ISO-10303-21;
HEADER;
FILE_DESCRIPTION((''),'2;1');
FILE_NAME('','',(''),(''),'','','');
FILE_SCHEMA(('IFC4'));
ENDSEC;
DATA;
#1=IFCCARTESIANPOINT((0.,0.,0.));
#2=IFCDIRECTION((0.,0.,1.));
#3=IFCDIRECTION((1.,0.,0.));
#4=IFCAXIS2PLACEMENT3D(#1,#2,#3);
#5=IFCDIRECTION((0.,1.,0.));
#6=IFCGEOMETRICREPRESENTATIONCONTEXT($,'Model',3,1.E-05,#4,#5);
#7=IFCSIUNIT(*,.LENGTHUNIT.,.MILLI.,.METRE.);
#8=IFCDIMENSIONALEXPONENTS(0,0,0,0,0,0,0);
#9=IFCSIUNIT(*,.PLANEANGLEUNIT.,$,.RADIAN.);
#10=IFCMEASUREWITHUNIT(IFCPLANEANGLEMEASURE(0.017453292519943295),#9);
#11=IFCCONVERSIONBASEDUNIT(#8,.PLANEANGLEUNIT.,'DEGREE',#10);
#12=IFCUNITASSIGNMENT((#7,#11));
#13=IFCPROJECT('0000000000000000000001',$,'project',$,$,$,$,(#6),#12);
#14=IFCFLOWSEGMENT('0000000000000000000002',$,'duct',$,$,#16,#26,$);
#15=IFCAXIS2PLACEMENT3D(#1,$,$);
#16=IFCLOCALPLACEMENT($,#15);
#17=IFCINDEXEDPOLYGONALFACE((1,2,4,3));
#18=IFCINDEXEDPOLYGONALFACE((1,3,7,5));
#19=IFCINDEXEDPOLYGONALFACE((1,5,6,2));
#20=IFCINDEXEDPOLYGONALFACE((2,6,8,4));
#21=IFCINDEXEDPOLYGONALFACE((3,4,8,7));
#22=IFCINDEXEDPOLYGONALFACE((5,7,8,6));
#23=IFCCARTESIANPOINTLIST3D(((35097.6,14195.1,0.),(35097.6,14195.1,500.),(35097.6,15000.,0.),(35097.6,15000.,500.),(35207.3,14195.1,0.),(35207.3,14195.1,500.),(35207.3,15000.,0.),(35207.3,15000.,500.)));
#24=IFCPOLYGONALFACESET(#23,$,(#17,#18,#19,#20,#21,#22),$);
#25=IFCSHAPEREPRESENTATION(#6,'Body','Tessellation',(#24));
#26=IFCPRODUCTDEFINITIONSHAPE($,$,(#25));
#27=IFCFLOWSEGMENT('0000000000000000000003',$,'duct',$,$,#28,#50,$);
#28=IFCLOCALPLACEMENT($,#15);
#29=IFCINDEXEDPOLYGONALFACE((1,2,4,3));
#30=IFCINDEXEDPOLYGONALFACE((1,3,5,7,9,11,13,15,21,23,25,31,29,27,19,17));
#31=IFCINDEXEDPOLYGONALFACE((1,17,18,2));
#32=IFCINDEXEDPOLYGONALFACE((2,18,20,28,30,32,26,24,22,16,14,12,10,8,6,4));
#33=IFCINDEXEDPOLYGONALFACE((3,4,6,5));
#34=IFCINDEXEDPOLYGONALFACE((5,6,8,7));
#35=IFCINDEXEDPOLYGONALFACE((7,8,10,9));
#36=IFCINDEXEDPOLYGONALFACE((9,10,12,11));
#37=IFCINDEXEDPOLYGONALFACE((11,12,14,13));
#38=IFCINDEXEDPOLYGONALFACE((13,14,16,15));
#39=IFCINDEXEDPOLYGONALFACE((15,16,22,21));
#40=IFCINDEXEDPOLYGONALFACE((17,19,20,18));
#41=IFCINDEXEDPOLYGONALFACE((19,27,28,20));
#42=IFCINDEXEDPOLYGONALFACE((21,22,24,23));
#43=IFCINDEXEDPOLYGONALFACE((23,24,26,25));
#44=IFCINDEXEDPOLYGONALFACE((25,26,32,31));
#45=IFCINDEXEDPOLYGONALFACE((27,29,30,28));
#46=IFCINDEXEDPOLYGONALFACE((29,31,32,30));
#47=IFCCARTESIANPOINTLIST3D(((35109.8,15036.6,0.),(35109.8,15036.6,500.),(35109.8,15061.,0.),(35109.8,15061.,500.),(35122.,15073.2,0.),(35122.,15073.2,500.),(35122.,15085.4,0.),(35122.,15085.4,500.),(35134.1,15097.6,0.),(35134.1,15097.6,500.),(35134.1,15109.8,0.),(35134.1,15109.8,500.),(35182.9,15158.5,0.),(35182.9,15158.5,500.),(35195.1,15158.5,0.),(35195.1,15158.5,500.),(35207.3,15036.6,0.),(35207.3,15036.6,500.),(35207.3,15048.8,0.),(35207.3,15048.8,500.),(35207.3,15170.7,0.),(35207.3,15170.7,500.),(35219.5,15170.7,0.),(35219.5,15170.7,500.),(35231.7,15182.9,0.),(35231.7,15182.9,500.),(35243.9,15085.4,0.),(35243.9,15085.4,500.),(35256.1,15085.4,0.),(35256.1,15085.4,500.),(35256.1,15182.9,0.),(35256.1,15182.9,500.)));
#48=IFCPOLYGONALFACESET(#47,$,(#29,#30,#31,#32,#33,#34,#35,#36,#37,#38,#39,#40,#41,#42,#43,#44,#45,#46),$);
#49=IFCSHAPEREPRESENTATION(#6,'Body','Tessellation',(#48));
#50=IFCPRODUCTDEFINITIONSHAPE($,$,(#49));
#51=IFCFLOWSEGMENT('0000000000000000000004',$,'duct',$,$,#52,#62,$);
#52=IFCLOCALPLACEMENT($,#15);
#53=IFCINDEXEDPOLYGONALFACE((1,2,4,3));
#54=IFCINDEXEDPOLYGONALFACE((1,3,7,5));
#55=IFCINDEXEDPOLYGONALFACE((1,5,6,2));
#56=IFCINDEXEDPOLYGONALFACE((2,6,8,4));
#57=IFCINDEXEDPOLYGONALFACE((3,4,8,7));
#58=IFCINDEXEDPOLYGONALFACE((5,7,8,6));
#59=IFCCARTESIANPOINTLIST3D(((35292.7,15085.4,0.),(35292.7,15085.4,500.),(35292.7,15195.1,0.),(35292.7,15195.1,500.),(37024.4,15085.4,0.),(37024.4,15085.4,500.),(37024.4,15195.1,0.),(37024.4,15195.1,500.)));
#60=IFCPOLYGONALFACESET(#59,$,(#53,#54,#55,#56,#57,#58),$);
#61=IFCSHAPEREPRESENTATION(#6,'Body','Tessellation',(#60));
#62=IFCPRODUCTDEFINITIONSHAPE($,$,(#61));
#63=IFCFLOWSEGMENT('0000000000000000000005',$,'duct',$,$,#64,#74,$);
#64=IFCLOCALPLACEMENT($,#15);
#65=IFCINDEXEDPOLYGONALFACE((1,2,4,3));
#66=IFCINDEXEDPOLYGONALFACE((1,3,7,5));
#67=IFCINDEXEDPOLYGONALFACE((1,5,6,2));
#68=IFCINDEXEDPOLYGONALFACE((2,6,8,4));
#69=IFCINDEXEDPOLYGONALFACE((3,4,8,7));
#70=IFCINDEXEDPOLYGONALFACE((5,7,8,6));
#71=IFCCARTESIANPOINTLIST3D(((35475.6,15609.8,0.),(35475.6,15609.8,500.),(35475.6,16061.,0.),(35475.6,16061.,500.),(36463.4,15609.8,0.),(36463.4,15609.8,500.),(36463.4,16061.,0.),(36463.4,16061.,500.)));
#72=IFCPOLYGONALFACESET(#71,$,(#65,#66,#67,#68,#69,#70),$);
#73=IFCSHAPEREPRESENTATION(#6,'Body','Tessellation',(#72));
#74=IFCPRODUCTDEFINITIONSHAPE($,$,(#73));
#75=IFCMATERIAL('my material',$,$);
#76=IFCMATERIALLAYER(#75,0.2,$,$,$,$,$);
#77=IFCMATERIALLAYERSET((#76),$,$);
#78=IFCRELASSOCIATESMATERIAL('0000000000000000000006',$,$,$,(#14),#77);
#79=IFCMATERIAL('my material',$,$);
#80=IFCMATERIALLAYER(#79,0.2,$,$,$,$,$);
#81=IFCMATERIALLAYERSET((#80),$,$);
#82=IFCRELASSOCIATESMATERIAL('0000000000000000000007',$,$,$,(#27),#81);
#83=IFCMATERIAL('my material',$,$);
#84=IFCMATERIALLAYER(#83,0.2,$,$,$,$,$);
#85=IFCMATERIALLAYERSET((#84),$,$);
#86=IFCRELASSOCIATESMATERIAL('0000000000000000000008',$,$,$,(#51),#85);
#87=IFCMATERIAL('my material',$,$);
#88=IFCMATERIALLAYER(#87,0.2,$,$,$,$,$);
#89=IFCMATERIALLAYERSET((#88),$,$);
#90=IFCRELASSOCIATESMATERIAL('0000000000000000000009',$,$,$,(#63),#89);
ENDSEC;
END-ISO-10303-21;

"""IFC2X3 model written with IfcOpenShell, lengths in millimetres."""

from ifc_helpers import new_model, entity, si_unit, converted_unit, direction, origin_with_axes, place, context, project, polyline, outline, extrude, material, layer, layer_set, layer_usage, element, save


model = new_model("IFC2X3")

# Units and contexts
model_context = context("Model", 3, precision=1e-05, world=origin_with_axes(), true_north=direction((0.0, 1.0, 0.0)))
ifc_project = project(units=[si_unit("LENGTHUNIT", "METRE", prefix="MILLI"), converted_unit("PLANEANGLEUNIT", "DEGREE", entity("IfcPlaneAngleMeasure", 0.017453292519943295), si_unit("PLANEANGLEUNIT", "RADIAN"), dimensions=[0, 0, 0, 0, 0, 0, 0])], contexts=[model_context])

# Flow segments
ifc_material_1 = material(Name="my material")
ifc_layer_1 = layer(ifc_material_1, 0.2)
ifc_layer_set_1 = layer_set([ifc_layer_1])
ifc_layer_usage_1 = layer_usage(ifc_layer_set_1, "AXIS2", "POSITIVE", -0.1)
flow_segment_1_placement = place(None, origin_with_axes())
element("IfcFlowSegment", 1, at=flow_segment_1_placement, material=ifc_layer_usage_1, Name="duct", context=model_context, shape_type="SweptSolid", body=[
    extrude(outline(polyline([(35097.6, 14195.1), (35207.3, 14195.1), (35207.3, 15000.0), (35097.6, 15000.0), (35097.6, 14195.1)])), origin_with_axes(), (0.0, 0.0, 1.0), 500.0),
])
ifc_material_2 = material(Name="my material")
ifc_layer_2 = layer(ifc_material_2, 0.2)
ifc_layer_set_2 = layer_set([ifc_layer_2])
ifc_layer_usage_2 = layer_usage(ifc_layer_set_2, "AXIS2", "POSITIVE", -0.1)
flow_segment_2_placement = place(None, origin_with_axes())
element("IfcFlowSegment", 2, at=flow_segment_2_placement, material=ifc_layer_usage_2, Name="duct", context=model_context, shape_type="SweptSolid", body=[
    extrude(outline(polyline([(35109.8, 15036.6), (35207.3, 15036.6), (35207.3, 15048.8), (35243.9, 15085.4), (35256.1, 15085.4), (35256.1, 15182.9), (35231.7, 15182.9), (35219.5, 15170.7), (35207.3, 15170.7), (35195.1, 15158.5), (35182.9, 15158.5), (35134.1, 15109.8), (35134.1, 15097.6), (35122.0, 15085.4), (35122.0, 15073.2), (35109.8, 15061.0), (35109.8, 15036.6)])), origin_with_axes(), (0.0, 0.0, 1.0), 500.0),
])
ifc_material_3 = material(Name="my material")
ifc_layer_3 = layer(ifc_material_3, 0.2)
ifc_layer_set_3 = layer_set([ifc_layer_3])
ifc_layer_usage_3 = layer_usage(ifc_layer_set_3, "AXIS2", "POSITIVE", -0.1)
flow_segment_3_placement = place(None, origin_with_axes())
element("IfcFlowSegment", 3, at=flow_segment_3_placement, material=ifc_layer_usage_3, Name="duct", context=model_context, shape_type="SweptSolid", body=[
    extrude(outline(polyline([(35292.7, 15085.4), (37024.4, 15085.4), (37024.4, 15195.1), (35292.7, 15195.1), (35292.7, 15085.4)])), origin_with_axes(), (0.0, 0.0, 1.0), 500.0),
])
ifc_material_4 = material(Name="my material")
ifc_layer_4 = layer(ifc_material_4, 0.2)
ifc_layer_set_4 = layer_set([ifc_layer_4])
ifc_layer_usage_4 = layer_usage(ifc_layer_set_4, "AXIS2", "POSITIVE", -0.1)
flow_segment_4_placement = place(None, origin_with_axes())
element("IfcFlowSegment", 4, at=flow_segment_4_placement, material=ifc_layer_usage_4, Name="duct", context=model_context, shape_type="SweptSolid", body=[
    extrude(outline(polyline([(35475.6, 15609.8), (36463.4, 15609.8), (36463.4, 16061.0), (35475.6, 16061.0), (35475.6, 15609.8)])), origin_with_axes(), (0.0, 0.0, 1.0), 500.0),
])

save(model, "model.ifc")
